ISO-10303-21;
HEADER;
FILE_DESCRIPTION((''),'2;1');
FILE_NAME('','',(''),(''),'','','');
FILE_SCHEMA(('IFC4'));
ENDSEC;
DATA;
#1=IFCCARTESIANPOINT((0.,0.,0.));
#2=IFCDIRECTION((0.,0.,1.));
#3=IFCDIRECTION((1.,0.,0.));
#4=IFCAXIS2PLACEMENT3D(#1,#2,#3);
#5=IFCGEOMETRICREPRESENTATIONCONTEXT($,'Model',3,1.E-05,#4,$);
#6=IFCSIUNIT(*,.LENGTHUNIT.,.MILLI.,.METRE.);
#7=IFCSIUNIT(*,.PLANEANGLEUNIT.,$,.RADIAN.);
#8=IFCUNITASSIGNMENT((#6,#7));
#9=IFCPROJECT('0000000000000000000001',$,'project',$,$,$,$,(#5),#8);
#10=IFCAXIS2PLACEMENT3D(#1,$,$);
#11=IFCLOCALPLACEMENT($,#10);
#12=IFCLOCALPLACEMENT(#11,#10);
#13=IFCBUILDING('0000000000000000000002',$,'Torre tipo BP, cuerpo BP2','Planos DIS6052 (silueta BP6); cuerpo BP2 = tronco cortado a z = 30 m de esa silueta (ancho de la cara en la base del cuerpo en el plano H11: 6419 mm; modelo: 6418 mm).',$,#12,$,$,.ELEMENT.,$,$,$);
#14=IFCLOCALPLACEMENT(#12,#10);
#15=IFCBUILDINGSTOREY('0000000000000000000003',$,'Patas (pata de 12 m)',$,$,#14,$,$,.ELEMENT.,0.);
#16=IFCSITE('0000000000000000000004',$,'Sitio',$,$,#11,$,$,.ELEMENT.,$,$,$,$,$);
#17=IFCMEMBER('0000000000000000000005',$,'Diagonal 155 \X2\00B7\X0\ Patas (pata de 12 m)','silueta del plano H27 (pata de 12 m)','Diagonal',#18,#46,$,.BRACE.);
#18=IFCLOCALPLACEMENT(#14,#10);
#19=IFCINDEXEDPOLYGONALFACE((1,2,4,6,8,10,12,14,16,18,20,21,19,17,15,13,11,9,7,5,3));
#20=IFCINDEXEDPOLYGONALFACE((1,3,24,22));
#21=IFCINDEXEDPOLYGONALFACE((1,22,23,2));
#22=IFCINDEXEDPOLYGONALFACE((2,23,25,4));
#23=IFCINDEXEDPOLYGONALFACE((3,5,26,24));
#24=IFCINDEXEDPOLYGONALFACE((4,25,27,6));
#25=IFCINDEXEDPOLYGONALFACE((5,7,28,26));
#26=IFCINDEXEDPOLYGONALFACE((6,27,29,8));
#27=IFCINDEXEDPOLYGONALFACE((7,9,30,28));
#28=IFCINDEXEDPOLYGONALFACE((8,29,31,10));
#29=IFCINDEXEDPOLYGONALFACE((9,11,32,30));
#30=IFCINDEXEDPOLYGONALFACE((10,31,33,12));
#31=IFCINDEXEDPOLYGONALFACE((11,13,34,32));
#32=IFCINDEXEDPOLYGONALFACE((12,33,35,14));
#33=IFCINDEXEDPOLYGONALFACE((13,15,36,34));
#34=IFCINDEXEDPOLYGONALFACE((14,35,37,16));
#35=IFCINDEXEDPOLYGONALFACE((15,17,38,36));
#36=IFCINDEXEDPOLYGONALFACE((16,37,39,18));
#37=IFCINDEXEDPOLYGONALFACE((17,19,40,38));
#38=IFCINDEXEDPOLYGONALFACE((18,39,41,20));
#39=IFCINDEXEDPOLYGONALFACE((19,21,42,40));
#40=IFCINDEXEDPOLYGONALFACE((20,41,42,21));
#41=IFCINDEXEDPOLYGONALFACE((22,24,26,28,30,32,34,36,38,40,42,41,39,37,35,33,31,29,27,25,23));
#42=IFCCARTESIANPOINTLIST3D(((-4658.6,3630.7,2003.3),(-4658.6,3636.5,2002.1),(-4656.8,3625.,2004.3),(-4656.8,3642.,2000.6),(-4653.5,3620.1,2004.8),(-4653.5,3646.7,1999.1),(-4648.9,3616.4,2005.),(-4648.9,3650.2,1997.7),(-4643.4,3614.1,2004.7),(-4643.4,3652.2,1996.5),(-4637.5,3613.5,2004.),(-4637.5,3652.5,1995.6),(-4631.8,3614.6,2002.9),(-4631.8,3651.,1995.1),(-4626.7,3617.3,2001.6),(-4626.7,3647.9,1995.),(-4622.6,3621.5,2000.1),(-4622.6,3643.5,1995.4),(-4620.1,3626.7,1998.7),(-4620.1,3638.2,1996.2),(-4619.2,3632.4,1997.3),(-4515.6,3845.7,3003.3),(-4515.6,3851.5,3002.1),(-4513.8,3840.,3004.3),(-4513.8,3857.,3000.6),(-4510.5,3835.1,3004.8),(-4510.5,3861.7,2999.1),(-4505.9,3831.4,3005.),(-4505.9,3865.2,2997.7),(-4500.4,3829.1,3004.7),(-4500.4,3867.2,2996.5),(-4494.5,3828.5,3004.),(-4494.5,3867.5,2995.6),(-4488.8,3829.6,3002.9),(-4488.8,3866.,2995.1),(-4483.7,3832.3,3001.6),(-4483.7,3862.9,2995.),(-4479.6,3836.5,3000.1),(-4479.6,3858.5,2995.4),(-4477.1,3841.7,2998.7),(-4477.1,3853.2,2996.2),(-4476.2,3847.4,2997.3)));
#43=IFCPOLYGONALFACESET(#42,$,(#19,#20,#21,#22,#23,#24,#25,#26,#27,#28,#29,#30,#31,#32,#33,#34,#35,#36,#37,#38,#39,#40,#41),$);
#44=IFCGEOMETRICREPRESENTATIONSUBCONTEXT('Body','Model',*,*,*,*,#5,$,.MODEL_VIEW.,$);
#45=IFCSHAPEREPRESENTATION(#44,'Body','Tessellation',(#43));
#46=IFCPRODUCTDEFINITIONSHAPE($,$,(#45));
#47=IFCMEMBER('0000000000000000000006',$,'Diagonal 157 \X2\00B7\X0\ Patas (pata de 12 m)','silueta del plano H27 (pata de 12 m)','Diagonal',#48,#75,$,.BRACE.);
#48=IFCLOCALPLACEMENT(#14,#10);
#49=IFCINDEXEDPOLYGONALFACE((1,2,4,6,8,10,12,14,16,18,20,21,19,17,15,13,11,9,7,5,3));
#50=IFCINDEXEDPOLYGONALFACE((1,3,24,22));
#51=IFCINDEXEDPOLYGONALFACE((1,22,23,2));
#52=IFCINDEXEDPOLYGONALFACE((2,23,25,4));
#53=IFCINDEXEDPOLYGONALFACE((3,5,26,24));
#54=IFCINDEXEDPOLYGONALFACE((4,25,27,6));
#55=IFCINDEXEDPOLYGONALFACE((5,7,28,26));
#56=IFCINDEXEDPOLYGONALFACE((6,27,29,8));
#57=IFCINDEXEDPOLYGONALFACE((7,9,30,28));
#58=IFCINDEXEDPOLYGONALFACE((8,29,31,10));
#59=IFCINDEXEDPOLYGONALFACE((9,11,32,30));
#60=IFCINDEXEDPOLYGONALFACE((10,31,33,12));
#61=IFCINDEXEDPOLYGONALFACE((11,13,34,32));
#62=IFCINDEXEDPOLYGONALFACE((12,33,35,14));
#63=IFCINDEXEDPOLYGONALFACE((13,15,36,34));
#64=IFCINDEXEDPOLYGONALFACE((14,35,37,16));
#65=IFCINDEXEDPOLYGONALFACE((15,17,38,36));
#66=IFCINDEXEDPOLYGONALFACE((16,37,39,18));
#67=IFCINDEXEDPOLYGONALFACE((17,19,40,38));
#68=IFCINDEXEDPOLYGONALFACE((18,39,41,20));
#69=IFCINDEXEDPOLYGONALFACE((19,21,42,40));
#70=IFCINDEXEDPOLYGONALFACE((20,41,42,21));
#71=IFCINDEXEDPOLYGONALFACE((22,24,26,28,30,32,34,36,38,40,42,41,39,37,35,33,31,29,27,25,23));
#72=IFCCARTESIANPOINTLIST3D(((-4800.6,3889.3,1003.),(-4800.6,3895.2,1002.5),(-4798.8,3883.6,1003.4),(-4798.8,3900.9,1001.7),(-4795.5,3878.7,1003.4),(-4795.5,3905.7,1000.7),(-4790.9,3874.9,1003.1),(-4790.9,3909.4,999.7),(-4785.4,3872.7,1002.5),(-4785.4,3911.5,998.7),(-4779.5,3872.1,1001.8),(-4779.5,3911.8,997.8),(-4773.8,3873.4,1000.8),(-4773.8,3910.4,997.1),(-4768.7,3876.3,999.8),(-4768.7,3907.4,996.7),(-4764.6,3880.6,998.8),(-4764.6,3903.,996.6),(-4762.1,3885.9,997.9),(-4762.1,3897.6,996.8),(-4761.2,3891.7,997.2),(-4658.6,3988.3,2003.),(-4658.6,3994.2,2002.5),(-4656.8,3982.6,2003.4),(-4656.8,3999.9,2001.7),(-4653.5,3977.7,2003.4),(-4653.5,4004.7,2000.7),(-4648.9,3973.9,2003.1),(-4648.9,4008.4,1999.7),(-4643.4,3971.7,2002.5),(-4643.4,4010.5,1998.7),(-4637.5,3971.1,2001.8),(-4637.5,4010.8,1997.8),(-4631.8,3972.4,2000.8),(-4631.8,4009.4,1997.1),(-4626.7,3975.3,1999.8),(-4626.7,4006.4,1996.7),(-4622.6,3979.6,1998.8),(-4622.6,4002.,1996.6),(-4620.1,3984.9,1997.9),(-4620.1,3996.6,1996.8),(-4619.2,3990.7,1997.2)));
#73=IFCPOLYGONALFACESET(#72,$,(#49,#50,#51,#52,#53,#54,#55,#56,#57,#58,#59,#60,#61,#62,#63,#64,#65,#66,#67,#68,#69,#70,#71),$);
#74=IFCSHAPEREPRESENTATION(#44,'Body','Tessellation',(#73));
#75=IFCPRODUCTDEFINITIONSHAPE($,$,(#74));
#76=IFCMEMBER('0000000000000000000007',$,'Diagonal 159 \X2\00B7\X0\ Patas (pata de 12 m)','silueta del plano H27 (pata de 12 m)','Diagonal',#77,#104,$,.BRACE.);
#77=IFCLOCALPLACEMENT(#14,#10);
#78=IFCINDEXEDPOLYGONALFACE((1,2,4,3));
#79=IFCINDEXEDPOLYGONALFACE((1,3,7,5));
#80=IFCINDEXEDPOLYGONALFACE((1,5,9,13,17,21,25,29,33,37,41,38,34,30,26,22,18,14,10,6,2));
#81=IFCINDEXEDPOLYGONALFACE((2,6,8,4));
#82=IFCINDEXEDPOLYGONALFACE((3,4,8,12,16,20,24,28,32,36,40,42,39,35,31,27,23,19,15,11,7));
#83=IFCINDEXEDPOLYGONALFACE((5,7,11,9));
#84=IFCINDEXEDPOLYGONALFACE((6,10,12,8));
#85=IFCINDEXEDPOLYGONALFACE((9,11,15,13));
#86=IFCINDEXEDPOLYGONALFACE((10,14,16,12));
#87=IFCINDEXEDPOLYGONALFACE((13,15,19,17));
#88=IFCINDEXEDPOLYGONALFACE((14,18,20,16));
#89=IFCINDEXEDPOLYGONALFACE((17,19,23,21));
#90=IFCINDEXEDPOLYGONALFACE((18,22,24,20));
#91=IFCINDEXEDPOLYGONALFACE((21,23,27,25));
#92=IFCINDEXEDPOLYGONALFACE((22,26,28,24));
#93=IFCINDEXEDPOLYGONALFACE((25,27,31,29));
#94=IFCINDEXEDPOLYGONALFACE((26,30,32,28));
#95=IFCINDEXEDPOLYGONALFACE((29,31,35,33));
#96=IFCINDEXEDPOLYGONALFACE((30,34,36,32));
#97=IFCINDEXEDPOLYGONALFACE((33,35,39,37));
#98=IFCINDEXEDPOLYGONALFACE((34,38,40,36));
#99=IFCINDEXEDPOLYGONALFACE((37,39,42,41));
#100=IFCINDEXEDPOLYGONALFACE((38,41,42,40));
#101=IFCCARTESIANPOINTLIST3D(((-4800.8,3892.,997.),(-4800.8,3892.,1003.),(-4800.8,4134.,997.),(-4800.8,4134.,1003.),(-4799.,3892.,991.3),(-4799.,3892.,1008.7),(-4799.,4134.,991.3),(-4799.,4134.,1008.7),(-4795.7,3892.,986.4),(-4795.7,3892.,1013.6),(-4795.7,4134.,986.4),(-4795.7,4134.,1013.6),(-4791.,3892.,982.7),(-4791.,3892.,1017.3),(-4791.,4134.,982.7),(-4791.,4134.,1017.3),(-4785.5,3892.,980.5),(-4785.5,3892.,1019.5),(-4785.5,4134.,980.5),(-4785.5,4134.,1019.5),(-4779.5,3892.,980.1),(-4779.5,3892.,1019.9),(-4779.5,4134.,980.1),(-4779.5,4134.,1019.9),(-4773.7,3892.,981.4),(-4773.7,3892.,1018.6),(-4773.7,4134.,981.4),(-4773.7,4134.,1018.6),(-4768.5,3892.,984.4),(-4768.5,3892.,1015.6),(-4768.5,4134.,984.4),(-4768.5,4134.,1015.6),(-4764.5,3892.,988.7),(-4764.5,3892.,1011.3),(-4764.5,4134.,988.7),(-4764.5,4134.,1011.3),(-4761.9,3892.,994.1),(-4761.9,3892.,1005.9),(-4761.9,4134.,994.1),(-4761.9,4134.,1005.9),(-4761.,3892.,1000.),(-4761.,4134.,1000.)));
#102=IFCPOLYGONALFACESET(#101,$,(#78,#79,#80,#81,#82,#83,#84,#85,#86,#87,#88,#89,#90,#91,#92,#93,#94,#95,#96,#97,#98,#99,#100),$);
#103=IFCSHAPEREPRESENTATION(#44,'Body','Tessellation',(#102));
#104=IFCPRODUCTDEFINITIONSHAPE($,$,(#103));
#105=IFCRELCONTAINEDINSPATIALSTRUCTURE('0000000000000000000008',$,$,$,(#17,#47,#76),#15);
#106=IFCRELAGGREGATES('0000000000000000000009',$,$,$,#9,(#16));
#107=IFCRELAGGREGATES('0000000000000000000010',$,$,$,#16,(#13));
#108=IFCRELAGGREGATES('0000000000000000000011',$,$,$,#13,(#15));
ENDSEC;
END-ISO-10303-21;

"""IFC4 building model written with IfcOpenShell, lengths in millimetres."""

from ifc_helpers import new_model, si_unit, frame, origin, origin_with_axes, place, context, subcontext, project, spatial, circle, extrude, element, save


model = new_model("IFC4")

# Units and contexts
model_context = context("Model", 3, precision=1e-05, world=origin_with_axes())
body_context = subcontext(model_context, "Body", "Model", "MODEL_VIEW")
ifc_project = project(units=[si_unit("LENGTHUNIT", "METRE", prefix="MILLI"), si_unit("PLANEANGLEUNIT", "RADIAN")], contexts=[model_context])

# Site, building, storey
site_placement = place(None, origin())
site = spatial("IfcSite", under=ifc_project, at=site_placement, Name="Sitio", CompositionType="ELEMENT")
building_placement = place(site_placement, origin())
building = spatial("IfcBuilding", under=site, at=building_placement, Name="Torre tipo BP, cuerpo BP2", Description="Planos DIS6052 (silueta BP6); cuerpo BP2 = tronco cortado a z = 30 m de esa silueta (ancho de la cara en la base del cuerpo en el plano H11: 6419 mm; modelo: 6418 mm).", CompositionType="ELEMENT")
storey_placement = place(building_placement, origin())
storey = spatial("IfcBuildingStorey", under=building, at=storey_placement, Name="Patas (pata de 12 m)", CompositionType="ELEMENT", Elevation=0.0)

# Members
member_1_placement = place(storey_placement, frame((-4639.0, 3633.0, 2000.0), z_axis=(0.138459, 0.208172, 0.968243), x_axis=(0.990368, -0.029104, -0.135365)))
element("IfcMember", 1, at=member_1_placement, inside=storey, Name="Diagonal 155 · Patas (pata de 12 m)", Description="silueta del plano H27 (pata de 12 m)", ObjectType="Diagonal", PredefinedType="BRACE", context=body_context, shape_type="SweptSolid", body=[
    extrude(circle(Radius=20.0), None, (0.0, 0.0, 1.0), 1032.8),
])
member_2_placement = place(storey_placement, frame((-4781.0, 3892.0, 1000.0), z_axis=(0.139919, 0.097549, 0.985346), x_axis=(0.990163, -0.013785, -0.139238)))
element("IfcMember", 2, at=member_2_placement, inside=storey, Name="Diagonal 157 · Patas (pata de 12 m)", Description="silueta del plano H27 (pata de 12 m)", ObjectType="Diagonal", PredefinedType="BRACE", context=body_context, shape_type="SweptSolid", body=[
    extrude(circle(Radius=20.0), None, (0.0, 0.0, 1.0), 1014.9),
])
member_3_placement = place(storey_placement, frame((-4781.0, 4134.0, 1000.0), z_axis=(0.0, -1.0, 0.0), x_axis=(1.0, 0.0, 0.0)))
element("IfcMember", 3, at=member_3_placement, inside=storey, Name="Diagonal 159 · Patas (pata de 12 m)", Description="silueta del plano H27 (pata de 12 m)", ObjectType="Diagonal", PredefinedType="BRACE", context=body_context, shape_type="SweptSolid", body=[
    extrude(circle(Radius=20.0), None, (0.0, 0.0, 1.0), 242.0),
])

save(model, "model.ifc")
